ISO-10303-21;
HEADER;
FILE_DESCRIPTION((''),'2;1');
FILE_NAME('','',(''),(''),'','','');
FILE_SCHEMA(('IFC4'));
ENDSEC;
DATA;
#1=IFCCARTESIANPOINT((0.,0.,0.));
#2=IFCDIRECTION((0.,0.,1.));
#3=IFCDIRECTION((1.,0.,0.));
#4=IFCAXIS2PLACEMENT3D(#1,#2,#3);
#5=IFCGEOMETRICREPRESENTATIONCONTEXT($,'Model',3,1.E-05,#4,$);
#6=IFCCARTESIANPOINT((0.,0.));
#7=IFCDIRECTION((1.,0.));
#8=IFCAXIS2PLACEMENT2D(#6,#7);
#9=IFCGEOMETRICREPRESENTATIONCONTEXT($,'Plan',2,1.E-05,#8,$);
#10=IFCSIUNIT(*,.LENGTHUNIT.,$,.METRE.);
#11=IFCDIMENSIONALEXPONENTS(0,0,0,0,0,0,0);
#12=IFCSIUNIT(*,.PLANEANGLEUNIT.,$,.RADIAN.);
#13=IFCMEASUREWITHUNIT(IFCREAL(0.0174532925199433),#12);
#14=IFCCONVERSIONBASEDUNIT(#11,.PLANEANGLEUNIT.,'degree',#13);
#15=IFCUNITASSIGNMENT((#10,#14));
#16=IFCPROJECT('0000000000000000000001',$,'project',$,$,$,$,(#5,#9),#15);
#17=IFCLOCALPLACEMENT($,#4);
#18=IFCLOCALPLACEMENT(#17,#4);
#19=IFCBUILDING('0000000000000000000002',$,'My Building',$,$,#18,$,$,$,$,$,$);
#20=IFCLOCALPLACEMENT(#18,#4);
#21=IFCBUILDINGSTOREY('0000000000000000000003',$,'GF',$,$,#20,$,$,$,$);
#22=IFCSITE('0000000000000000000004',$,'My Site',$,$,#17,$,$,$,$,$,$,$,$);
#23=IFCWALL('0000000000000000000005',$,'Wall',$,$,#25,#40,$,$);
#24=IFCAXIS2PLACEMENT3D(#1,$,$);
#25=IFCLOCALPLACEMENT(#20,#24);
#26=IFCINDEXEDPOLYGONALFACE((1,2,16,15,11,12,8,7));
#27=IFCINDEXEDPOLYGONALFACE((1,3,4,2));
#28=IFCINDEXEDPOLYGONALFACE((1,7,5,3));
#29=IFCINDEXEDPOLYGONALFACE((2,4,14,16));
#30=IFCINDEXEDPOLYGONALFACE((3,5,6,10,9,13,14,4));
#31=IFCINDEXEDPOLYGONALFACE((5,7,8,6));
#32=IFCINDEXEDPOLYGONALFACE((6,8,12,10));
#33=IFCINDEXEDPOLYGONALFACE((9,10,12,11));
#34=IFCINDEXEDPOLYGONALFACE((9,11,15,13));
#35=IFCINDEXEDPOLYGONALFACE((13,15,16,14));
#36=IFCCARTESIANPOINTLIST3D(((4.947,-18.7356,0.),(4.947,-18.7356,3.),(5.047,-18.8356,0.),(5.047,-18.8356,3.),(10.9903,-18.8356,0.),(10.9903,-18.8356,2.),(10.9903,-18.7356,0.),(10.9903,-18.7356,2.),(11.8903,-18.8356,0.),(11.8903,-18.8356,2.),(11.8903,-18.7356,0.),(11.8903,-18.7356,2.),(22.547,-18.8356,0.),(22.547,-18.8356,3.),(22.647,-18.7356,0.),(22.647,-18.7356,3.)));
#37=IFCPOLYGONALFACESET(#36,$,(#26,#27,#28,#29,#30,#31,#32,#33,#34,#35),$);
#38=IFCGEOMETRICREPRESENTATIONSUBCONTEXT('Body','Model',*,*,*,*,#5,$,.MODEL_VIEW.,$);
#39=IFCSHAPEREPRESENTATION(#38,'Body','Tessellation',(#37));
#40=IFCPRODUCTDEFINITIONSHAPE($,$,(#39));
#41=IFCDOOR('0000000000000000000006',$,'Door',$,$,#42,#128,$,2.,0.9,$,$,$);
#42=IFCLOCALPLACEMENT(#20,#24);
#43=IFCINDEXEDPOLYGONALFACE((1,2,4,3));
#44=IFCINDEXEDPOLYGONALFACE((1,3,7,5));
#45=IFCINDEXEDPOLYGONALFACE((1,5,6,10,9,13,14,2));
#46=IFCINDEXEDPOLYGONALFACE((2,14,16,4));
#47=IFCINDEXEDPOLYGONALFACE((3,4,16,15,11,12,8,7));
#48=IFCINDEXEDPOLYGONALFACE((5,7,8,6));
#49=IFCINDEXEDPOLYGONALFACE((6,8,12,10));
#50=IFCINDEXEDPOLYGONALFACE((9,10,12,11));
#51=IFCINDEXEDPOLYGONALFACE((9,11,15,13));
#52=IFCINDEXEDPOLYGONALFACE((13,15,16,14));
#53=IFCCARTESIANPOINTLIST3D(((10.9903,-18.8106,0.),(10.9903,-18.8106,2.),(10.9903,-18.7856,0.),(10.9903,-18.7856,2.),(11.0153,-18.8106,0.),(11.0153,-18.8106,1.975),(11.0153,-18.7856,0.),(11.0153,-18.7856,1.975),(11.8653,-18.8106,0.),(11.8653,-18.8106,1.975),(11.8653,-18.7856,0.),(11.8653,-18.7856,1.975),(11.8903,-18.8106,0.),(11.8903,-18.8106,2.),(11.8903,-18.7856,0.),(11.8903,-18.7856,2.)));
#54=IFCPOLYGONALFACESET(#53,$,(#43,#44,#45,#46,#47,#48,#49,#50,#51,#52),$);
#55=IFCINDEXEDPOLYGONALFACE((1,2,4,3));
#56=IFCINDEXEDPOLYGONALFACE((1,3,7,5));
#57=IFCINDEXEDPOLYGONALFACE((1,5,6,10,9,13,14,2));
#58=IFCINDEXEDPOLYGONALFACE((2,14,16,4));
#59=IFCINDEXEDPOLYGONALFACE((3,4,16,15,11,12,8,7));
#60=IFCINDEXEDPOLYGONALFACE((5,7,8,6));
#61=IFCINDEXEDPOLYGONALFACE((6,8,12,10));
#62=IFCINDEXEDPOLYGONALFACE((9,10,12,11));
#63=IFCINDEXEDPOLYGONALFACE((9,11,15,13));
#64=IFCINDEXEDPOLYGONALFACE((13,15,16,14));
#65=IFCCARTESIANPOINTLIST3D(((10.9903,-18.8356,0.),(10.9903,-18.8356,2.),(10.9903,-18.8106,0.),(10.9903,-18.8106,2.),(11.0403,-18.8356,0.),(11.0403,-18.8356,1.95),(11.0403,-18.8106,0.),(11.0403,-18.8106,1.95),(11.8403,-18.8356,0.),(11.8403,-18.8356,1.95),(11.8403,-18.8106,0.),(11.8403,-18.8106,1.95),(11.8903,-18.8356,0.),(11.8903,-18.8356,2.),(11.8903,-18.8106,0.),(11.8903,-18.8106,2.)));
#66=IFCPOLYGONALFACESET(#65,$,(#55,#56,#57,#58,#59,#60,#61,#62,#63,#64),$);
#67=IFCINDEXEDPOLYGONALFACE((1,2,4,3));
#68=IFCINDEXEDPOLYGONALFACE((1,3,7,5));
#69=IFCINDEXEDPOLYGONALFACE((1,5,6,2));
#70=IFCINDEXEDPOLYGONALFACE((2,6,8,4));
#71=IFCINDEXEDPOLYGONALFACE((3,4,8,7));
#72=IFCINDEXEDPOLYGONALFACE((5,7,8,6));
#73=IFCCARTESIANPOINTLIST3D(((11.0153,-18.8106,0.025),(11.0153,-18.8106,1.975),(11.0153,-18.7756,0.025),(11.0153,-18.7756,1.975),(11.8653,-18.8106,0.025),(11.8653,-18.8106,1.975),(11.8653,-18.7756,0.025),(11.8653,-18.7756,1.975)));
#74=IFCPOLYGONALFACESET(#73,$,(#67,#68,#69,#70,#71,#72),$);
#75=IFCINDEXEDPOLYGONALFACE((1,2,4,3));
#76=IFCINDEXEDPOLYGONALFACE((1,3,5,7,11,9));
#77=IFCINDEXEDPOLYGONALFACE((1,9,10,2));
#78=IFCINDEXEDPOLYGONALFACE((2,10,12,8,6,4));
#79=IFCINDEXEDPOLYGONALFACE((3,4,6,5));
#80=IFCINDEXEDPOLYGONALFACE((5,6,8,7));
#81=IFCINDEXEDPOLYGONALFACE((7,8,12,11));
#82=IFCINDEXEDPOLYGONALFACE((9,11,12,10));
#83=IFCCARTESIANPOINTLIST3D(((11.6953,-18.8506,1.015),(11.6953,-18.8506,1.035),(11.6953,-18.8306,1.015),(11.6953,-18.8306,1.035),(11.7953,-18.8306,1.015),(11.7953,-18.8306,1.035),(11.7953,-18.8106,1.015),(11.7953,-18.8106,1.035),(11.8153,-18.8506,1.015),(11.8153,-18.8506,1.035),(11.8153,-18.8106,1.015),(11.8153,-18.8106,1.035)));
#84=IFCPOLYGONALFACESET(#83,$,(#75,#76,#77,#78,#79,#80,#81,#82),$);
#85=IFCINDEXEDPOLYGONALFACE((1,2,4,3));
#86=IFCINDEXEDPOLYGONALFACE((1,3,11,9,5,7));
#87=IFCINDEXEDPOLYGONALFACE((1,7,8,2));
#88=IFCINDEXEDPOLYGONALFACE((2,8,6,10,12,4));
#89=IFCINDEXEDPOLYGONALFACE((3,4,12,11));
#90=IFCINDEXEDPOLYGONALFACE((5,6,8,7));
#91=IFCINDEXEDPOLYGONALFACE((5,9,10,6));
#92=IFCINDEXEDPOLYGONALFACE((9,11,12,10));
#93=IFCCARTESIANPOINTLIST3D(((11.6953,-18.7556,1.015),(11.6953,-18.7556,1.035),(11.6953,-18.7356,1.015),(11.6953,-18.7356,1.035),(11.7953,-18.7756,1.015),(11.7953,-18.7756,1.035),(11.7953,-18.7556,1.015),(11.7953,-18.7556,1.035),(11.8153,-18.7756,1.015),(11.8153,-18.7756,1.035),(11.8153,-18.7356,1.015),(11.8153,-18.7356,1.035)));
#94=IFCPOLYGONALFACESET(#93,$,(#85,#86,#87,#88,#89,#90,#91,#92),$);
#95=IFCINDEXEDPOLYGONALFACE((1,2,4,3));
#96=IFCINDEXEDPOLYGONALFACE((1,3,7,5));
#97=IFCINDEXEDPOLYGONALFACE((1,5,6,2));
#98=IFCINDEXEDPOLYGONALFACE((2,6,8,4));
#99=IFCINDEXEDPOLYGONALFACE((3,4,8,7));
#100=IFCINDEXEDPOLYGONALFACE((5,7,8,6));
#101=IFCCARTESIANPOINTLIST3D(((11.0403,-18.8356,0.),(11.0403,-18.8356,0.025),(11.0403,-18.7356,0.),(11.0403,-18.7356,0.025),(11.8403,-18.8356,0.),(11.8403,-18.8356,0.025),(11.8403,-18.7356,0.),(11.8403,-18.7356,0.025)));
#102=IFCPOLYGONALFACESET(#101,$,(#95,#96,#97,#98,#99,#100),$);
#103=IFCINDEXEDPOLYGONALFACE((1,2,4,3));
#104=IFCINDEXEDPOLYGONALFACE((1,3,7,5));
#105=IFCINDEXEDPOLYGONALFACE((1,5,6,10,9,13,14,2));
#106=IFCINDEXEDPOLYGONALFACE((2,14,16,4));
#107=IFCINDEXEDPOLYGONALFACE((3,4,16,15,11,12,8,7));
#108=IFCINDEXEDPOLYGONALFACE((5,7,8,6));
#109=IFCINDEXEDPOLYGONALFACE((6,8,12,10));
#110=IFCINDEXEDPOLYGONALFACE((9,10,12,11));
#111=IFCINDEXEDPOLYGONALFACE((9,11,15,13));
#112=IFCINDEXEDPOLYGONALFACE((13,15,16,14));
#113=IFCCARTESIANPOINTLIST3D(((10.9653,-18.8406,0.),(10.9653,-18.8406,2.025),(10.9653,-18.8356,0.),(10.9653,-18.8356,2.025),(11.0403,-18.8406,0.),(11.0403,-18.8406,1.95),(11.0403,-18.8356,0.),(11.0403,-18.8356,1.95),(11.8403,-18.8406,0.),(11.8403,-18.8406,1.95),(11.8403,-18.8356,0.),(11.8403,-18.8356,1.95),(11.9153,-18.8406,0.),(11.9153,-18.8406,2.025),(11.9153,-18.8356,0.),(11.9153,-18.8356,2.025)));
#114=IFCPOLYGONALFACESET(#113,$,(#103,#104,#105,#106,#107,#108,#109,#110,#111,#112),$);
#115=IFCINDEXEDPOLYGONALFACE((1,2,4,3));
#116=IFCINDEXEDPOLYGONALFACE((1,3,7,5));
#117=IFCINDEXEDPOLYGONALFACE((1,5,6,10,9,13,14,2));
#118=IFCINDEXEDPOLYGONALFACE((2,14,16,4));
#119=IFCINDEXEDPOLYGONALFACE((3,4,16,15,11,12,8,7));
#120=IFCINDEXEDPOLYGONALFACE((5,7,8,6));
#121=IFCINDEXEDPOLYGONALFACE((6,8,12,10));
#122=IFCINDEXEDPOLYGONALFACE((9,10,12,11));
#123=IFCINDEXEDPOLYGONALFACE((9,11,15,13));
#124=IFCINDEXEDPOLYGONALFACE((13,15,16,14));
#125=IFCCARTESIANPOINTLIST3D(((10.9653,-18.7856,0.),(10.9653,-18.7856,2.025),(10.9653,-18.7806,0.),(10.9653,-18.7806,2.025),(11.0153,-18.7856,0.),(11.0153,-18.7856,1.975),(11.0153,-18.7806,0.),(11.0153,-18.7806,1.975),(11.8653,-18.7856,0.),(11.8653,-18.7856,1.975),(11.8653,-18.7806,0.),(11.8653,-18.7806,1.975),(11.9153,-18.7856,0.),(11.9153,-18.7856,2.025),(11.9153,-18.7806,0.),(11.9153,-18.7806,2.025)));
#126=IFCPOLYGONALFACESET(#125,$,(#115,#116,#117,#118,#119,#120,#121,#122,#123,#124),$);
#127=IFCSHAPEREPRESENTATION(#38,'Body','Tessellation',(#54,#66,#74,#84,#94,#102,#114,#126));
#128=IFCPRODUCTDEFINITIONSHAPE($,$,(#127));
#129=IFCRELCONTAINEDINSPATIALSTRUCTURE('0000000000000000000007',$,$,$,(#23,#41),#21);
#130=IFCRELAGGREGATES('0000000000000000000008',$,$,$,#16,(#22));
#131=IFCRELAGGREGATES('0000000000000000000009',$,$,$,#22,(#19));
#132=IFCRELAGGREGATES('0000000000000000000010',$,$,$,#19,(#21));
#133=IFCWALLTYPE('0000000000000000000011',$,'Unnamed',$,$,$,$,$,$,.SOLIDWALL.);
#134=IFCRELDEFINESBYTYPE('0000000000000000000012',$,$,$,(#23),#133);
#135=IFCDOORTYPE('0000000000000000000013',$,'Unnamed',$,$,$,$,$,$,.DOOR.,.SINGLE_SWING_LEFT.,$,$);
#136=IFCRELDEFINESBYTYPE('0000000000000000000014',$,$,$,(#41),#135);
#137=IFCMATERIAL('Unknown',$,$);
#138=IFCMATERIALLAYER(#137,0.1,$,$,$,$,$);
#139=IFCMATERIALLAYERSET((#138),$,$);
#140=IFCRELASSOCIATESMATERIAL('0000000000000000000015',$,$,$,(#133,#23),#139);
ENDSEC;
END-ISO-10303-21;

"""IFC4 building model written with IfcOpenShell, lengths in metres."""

from ifc_helpers import new_model, entity, si_unit, converted_unit, frame, origin_with_axes, origin_2d_with_axis, place, context, subcontext, project, spatial, line, indexed_curve, outline, extrude, shape, source, transform, mapped, material, layer, layer_set, layer_usage, type_object, type_shapes, element, fill, save


model = new_model("IFC4")

# Units and contexts
model_context = context("Model", 3, precision=1e-05, world=origin_with_axes())
plan_context = context("Plan", 2, precision=1e-05, world=origin_2d_with_axis())
body_context_1 = subcontext(model_context, "Body", "Model", "MODEL_VIEW")
body_context_2 = subcontext(plan_context, "Body", "Plan", "PLAN_VIEW")
ifc_project = project(units=[si_unit("LENGTHUNIT", "METRE"), converted_unit("PLANEANGLEUNIT", "degree", entity("IfcReal", 0.0174532925199433), si_unit("PLANEANGLEUNIT", "RADIAN"), dimensions=[0, 0, 0, 0, 0, 0, 0])], contexts=[model_context, plan_context])

# Site, building, storey
site_placement = place(None, origin_with_axes())
site = spatial("IfcSite", under=ifc_project, at=site_placement, Name="My Site")
building_placement = place(site_placement, origin_with_axes())
building = spatial("IfcBuilding", under=site, at=building_placement, Name="My Building")
storey_placement = place(building_placement, origin_with_axes())
storey = spatial("IfcBuildingStorey", under=building, at=storey_placement, Name="GF")

# Shared definitions
ifc_material = material(Name="Unknown")
ifc_layer = layer(ifc_material, 0.1)
ifc_layer_set = layer_set([ifc_layer])
wall_type = type_object("IfcWallType", Name="Unnamed", PredefinedType="SOLIDWALL", material=ifc_layer_set)

# Shared definitions
shared_shape_1 = source(origin_with_axes(), body_context_1, "Body", "SweptSolid", [
    extrude(outline(indexed_curve([(0.0, 0.0), (0.9, 0.0), (0.9, 2.0), (0.0, 2.0)], segments=[line(1, 2, 3, 4, 1)])), frame((0.0, -0.6, 0.0), z_axis=(0.0, -1.0, 0.0), x_axis=(1.0, 0.0, 0.0)), (0.0, 0.0, -1.0), 1.2),
])
door_type = type_object("IfcDoorType", Name="Unnamed", OperationType="SINGLE_SWING_LEFT", PredefinedType="DOOR")
shared_shape_2 = source(origin_with_axes(), body_context_1, "Body", "SweptSolid", [
    extrude(outline(indexed_curve([(0.0, 0.0), (0.0, 2.0), (0.9, 2.0), (0.9, 0.0), (0.875, 0.0), (0.875, 1.975), (0.025, 1.975), (0.025, 0.0)], segments=[line(1, 2, 3, 4, 5, 6, 7, 8, 1)])), frame((0.0, 0.025, 0.0), z_axis=(0.0, -1.0, 0.0), x_axis=(1.0, 0.0, 0.0)), (0.0, 0.0, -1.0), 0.025),
    extrude(outline(indexed_curve([(0.0, 0.0), (0.0, 2.0), (0.9, 2.0), (0.9, 0.0), (0.85, 0.0), (0.85, 1.95), (0.05, 1.95), (0.05, 0.0)], segments=[line(1, 2, 3, 4, 5, 6, 7, 8, 1)])), frame((0.0, 0.0, 0.0), z_axis=(0.0, -1.0, 0.0), x_axis=(1.0, 0.0, 0.0)), (0.0, 0.0, -1.0), 0.025),
    extrude(outline(indexed_curve([(0.0, 0.0), (0.85, 0.0), (0.85, 0.035), (0.0, 0.035)], segments=[line(1, 2, 3, 4, 1)])), frame((0.025, 0.025, 0.025), z_axis=(0.0, 0.0, 1.0), x_axis=(1.0, 0.0, 0.0)), (0.0, 0.0, 1.0), 1.95),
    extrude(outline(indexed_curve([(0.0, 0.0), (0.0, -0.04), (-0.12, -0.04), (-0.12, -0.02), (-0.02, -0.02), (-0.02, 0.0)], segments=[line(1, 2, 3, 4, 5, 6, 1)])), frame((0.825, 0.025, 1.015), z_axis=(0.0, 0.0, 1.0), x_axis=(1.0, 0.0, 0.0)), (0.0, 0.0, 1.0), 0.02),
    extrude(outline(indexed_curve([(0.0, 0.0), (0.0, 0.04), (-0.12, 0.04), (-0.12, 0.02), (-0.02, 0.02), (-0.02, 0.0)], segments=[line(1, 2, 3, 4, 5, 6, 1)])), frame((0.825, 0.06, 1.015), z_axis=(0.0, 0.0, 1.0), x_axis=(1.0, 0.0, 0.0)), (0.0, 0.0, 1.0), 0.02),
    extrude(outline(indexed_curve([(0.0, 0.0), (0.8, 0.0), (0.8, 0.1), (0.0, 0.1)], segments=[line(1, 2, 3, 4, 1)])), frame((0.05, 0.0, 0.0), z_axis=(0.0, 0.0, 1.0), x_axis=(1.0, 0.0, 0.0)), (0.0, 0.0, 1.0), 0.025),
    extrude(outline(indexed_curve([(0.0, 0.0), (0.0, 2.025), (0.95, 2.025), (0.95, 0.0), (0.875, 0.0), (0.875, 1.95), (0.075, 1.95), (0.075, 0.0)], segments=[line(1, 2, 3, 4, 5, 6, 7, 8, 1)])), frame((-0.025, -0.005, 0.0), z_axis=(0.0, -1.0, 0.0), x_axis=(1.0, 0.0, 0.0)), (0.0, 0.0, -1.0), 0.005),
    extrude(outline(indexed_curve([(0.0, 0.0), (0.0, 2.025), (0.95, 2.025), (0.95, 0.0), (0.9, 0.0), (0.9, 1.975), (0.05, 1.975), (0.05, 0.0)], segments=[line(1, 2, 3, 4, 5, 6, 7, 8, 1)])), frame((-0.025, 0.05, 0.0), z_axis=(0.0, -1.0, 0.0), x_axis=(1.0, 0.0, 0.0)), (0.0, 0.0, -1.0), 0.005),
])
shared_shape_3 = source(origin_with_axes(), body_context_2, "Body", "Curve2D", [
    entity("IfcIndexedPolyCurve", entity("IfcCartesianPointList2D", [[0.0, 0.0], [0.0, 0.05], [0.025, 0.05], [0.025, 0.025], [0.05, 0.025], [0.05, 0.0]]), [entity("IfcLineIndex", [1, 2, 3, 4, 5, 6, 1])]),
    entity("IfcIndexedPolyCurve", entity("IfcCartesianPointList2D", [[0.9, 0.0], [0.9, 0.05], [0.875, 0.05], [0.875, 0.025], [0.85, 0.025], [0.85, 0.0]]), [entity("IfcLineIndex", [1, 2, 3, 4, 5, 6, 1])]),
    entity("IfcTrimmedCurve", entity("IfcEllipse", entity("IfcAxis2Placement2D", entity("IfcCartesianPoint", [0.06, 0.05]), entity("IfcDirection", [1.0, 0.0])), 0.815, 0.85), [entity("IfcCartesianPoint", [0.875, 0.05])], [entity("IfcCartesianPoint", [0.06, 0.9])], True, "CARTESIAN"),
    entity("IfcIndexedPolyCurve", entity("IfcCartesianPointList2D", [[0.025, 0.05], [0.06, 0.05], [0.06, 0.9], [0.025, 0.9]]), [entity("IfcLineIndex", [1, 2, 3, 4, 1])]),
])
type_shapes(door_type, [shared_shape_2, shared_shape_3])

# Wall, opening, door
ifc_layer_usage_1 = layer_usage(ifc_layer_set, "AXIS2", "POSITIVE", 0.0)
wall_1_placement = place(storey_placement, frame((5.047, -18.8356, 0.0), z_axis=(0.0, 0.0, 1.0), x_axis=(1.0, 0.0, 0.0)))
wall_1 = element("IfcWall", 1, at=wall_1_placement, inside=storey, type_object=wall_type, material=ifc_layer_usage_1, Name="Wall", context=body_context_1, shape_type="SweptSolid", body=[
    extrude(outline(indexed_curve([(0.0, 0.0), (-0.1, 0.1), (17.6, 0.1), (17.5, 0.0)], segments=[line(1, 2, 3, 4, 1)])), origin_with_axes(), (0.0, 0.0, 1.0), 3.0),
])
opening_1_placement = place(wall_1_placement, frame((5.9433, 0.0, 0.0), z_axis=(0.0, 0.0, 1.0), x_axis=(1.0, 0.0, 0.0)))
opening_1 = element("IfcOpeningElement", 2, at=opening_1_placement, cuts=wall_1, PredefinedType="OPENING", context=body_context_1, shape_type="MappedRepresentation", body=[
    mapped(shared_shape_1, transform((0.0, 0.0, 0.0), x_axis=(1.0, 0.0, 0.0), y_axis=(0.0, 1.0, 0.0), z_axis=(0.0, 0.0, 1.0), scale=1.0)),
])
door_1_placement = place(opening_1_placement, origin_with_axes())
door_1 = element("IfcDoor", 3, at=door_1_placement, inside=storey, type_object=door_type, Name="Door", OverallHeight=2.0, OverallWidth=0.9, shapes=[
    shape(body_context_1, "Body", "MappedRepresentation", [mapped(shared_shape_2, transform((0.0, 0.0, 0.0), x_axis=(1.0, 0.0, 0.0), y_axis=(0.0, 1.0, 0.0), z_axis=(0.0, 0.0, 1.0), scale=1.0))]),
    shape(body_context_2, "Body", "MappedRepresentation", [mapped(shared_shape_3, transform((0.0, 0.0, 0.0), x_axis=(1.0, 0.0, 0.0), y_axis=(0.0, 1.0, 0.0), z_axis=(0.0, 0.0, 1.0), scale=1.0))]),
])
fill(opening_1, door_1)

save(model, "model.ifc")
